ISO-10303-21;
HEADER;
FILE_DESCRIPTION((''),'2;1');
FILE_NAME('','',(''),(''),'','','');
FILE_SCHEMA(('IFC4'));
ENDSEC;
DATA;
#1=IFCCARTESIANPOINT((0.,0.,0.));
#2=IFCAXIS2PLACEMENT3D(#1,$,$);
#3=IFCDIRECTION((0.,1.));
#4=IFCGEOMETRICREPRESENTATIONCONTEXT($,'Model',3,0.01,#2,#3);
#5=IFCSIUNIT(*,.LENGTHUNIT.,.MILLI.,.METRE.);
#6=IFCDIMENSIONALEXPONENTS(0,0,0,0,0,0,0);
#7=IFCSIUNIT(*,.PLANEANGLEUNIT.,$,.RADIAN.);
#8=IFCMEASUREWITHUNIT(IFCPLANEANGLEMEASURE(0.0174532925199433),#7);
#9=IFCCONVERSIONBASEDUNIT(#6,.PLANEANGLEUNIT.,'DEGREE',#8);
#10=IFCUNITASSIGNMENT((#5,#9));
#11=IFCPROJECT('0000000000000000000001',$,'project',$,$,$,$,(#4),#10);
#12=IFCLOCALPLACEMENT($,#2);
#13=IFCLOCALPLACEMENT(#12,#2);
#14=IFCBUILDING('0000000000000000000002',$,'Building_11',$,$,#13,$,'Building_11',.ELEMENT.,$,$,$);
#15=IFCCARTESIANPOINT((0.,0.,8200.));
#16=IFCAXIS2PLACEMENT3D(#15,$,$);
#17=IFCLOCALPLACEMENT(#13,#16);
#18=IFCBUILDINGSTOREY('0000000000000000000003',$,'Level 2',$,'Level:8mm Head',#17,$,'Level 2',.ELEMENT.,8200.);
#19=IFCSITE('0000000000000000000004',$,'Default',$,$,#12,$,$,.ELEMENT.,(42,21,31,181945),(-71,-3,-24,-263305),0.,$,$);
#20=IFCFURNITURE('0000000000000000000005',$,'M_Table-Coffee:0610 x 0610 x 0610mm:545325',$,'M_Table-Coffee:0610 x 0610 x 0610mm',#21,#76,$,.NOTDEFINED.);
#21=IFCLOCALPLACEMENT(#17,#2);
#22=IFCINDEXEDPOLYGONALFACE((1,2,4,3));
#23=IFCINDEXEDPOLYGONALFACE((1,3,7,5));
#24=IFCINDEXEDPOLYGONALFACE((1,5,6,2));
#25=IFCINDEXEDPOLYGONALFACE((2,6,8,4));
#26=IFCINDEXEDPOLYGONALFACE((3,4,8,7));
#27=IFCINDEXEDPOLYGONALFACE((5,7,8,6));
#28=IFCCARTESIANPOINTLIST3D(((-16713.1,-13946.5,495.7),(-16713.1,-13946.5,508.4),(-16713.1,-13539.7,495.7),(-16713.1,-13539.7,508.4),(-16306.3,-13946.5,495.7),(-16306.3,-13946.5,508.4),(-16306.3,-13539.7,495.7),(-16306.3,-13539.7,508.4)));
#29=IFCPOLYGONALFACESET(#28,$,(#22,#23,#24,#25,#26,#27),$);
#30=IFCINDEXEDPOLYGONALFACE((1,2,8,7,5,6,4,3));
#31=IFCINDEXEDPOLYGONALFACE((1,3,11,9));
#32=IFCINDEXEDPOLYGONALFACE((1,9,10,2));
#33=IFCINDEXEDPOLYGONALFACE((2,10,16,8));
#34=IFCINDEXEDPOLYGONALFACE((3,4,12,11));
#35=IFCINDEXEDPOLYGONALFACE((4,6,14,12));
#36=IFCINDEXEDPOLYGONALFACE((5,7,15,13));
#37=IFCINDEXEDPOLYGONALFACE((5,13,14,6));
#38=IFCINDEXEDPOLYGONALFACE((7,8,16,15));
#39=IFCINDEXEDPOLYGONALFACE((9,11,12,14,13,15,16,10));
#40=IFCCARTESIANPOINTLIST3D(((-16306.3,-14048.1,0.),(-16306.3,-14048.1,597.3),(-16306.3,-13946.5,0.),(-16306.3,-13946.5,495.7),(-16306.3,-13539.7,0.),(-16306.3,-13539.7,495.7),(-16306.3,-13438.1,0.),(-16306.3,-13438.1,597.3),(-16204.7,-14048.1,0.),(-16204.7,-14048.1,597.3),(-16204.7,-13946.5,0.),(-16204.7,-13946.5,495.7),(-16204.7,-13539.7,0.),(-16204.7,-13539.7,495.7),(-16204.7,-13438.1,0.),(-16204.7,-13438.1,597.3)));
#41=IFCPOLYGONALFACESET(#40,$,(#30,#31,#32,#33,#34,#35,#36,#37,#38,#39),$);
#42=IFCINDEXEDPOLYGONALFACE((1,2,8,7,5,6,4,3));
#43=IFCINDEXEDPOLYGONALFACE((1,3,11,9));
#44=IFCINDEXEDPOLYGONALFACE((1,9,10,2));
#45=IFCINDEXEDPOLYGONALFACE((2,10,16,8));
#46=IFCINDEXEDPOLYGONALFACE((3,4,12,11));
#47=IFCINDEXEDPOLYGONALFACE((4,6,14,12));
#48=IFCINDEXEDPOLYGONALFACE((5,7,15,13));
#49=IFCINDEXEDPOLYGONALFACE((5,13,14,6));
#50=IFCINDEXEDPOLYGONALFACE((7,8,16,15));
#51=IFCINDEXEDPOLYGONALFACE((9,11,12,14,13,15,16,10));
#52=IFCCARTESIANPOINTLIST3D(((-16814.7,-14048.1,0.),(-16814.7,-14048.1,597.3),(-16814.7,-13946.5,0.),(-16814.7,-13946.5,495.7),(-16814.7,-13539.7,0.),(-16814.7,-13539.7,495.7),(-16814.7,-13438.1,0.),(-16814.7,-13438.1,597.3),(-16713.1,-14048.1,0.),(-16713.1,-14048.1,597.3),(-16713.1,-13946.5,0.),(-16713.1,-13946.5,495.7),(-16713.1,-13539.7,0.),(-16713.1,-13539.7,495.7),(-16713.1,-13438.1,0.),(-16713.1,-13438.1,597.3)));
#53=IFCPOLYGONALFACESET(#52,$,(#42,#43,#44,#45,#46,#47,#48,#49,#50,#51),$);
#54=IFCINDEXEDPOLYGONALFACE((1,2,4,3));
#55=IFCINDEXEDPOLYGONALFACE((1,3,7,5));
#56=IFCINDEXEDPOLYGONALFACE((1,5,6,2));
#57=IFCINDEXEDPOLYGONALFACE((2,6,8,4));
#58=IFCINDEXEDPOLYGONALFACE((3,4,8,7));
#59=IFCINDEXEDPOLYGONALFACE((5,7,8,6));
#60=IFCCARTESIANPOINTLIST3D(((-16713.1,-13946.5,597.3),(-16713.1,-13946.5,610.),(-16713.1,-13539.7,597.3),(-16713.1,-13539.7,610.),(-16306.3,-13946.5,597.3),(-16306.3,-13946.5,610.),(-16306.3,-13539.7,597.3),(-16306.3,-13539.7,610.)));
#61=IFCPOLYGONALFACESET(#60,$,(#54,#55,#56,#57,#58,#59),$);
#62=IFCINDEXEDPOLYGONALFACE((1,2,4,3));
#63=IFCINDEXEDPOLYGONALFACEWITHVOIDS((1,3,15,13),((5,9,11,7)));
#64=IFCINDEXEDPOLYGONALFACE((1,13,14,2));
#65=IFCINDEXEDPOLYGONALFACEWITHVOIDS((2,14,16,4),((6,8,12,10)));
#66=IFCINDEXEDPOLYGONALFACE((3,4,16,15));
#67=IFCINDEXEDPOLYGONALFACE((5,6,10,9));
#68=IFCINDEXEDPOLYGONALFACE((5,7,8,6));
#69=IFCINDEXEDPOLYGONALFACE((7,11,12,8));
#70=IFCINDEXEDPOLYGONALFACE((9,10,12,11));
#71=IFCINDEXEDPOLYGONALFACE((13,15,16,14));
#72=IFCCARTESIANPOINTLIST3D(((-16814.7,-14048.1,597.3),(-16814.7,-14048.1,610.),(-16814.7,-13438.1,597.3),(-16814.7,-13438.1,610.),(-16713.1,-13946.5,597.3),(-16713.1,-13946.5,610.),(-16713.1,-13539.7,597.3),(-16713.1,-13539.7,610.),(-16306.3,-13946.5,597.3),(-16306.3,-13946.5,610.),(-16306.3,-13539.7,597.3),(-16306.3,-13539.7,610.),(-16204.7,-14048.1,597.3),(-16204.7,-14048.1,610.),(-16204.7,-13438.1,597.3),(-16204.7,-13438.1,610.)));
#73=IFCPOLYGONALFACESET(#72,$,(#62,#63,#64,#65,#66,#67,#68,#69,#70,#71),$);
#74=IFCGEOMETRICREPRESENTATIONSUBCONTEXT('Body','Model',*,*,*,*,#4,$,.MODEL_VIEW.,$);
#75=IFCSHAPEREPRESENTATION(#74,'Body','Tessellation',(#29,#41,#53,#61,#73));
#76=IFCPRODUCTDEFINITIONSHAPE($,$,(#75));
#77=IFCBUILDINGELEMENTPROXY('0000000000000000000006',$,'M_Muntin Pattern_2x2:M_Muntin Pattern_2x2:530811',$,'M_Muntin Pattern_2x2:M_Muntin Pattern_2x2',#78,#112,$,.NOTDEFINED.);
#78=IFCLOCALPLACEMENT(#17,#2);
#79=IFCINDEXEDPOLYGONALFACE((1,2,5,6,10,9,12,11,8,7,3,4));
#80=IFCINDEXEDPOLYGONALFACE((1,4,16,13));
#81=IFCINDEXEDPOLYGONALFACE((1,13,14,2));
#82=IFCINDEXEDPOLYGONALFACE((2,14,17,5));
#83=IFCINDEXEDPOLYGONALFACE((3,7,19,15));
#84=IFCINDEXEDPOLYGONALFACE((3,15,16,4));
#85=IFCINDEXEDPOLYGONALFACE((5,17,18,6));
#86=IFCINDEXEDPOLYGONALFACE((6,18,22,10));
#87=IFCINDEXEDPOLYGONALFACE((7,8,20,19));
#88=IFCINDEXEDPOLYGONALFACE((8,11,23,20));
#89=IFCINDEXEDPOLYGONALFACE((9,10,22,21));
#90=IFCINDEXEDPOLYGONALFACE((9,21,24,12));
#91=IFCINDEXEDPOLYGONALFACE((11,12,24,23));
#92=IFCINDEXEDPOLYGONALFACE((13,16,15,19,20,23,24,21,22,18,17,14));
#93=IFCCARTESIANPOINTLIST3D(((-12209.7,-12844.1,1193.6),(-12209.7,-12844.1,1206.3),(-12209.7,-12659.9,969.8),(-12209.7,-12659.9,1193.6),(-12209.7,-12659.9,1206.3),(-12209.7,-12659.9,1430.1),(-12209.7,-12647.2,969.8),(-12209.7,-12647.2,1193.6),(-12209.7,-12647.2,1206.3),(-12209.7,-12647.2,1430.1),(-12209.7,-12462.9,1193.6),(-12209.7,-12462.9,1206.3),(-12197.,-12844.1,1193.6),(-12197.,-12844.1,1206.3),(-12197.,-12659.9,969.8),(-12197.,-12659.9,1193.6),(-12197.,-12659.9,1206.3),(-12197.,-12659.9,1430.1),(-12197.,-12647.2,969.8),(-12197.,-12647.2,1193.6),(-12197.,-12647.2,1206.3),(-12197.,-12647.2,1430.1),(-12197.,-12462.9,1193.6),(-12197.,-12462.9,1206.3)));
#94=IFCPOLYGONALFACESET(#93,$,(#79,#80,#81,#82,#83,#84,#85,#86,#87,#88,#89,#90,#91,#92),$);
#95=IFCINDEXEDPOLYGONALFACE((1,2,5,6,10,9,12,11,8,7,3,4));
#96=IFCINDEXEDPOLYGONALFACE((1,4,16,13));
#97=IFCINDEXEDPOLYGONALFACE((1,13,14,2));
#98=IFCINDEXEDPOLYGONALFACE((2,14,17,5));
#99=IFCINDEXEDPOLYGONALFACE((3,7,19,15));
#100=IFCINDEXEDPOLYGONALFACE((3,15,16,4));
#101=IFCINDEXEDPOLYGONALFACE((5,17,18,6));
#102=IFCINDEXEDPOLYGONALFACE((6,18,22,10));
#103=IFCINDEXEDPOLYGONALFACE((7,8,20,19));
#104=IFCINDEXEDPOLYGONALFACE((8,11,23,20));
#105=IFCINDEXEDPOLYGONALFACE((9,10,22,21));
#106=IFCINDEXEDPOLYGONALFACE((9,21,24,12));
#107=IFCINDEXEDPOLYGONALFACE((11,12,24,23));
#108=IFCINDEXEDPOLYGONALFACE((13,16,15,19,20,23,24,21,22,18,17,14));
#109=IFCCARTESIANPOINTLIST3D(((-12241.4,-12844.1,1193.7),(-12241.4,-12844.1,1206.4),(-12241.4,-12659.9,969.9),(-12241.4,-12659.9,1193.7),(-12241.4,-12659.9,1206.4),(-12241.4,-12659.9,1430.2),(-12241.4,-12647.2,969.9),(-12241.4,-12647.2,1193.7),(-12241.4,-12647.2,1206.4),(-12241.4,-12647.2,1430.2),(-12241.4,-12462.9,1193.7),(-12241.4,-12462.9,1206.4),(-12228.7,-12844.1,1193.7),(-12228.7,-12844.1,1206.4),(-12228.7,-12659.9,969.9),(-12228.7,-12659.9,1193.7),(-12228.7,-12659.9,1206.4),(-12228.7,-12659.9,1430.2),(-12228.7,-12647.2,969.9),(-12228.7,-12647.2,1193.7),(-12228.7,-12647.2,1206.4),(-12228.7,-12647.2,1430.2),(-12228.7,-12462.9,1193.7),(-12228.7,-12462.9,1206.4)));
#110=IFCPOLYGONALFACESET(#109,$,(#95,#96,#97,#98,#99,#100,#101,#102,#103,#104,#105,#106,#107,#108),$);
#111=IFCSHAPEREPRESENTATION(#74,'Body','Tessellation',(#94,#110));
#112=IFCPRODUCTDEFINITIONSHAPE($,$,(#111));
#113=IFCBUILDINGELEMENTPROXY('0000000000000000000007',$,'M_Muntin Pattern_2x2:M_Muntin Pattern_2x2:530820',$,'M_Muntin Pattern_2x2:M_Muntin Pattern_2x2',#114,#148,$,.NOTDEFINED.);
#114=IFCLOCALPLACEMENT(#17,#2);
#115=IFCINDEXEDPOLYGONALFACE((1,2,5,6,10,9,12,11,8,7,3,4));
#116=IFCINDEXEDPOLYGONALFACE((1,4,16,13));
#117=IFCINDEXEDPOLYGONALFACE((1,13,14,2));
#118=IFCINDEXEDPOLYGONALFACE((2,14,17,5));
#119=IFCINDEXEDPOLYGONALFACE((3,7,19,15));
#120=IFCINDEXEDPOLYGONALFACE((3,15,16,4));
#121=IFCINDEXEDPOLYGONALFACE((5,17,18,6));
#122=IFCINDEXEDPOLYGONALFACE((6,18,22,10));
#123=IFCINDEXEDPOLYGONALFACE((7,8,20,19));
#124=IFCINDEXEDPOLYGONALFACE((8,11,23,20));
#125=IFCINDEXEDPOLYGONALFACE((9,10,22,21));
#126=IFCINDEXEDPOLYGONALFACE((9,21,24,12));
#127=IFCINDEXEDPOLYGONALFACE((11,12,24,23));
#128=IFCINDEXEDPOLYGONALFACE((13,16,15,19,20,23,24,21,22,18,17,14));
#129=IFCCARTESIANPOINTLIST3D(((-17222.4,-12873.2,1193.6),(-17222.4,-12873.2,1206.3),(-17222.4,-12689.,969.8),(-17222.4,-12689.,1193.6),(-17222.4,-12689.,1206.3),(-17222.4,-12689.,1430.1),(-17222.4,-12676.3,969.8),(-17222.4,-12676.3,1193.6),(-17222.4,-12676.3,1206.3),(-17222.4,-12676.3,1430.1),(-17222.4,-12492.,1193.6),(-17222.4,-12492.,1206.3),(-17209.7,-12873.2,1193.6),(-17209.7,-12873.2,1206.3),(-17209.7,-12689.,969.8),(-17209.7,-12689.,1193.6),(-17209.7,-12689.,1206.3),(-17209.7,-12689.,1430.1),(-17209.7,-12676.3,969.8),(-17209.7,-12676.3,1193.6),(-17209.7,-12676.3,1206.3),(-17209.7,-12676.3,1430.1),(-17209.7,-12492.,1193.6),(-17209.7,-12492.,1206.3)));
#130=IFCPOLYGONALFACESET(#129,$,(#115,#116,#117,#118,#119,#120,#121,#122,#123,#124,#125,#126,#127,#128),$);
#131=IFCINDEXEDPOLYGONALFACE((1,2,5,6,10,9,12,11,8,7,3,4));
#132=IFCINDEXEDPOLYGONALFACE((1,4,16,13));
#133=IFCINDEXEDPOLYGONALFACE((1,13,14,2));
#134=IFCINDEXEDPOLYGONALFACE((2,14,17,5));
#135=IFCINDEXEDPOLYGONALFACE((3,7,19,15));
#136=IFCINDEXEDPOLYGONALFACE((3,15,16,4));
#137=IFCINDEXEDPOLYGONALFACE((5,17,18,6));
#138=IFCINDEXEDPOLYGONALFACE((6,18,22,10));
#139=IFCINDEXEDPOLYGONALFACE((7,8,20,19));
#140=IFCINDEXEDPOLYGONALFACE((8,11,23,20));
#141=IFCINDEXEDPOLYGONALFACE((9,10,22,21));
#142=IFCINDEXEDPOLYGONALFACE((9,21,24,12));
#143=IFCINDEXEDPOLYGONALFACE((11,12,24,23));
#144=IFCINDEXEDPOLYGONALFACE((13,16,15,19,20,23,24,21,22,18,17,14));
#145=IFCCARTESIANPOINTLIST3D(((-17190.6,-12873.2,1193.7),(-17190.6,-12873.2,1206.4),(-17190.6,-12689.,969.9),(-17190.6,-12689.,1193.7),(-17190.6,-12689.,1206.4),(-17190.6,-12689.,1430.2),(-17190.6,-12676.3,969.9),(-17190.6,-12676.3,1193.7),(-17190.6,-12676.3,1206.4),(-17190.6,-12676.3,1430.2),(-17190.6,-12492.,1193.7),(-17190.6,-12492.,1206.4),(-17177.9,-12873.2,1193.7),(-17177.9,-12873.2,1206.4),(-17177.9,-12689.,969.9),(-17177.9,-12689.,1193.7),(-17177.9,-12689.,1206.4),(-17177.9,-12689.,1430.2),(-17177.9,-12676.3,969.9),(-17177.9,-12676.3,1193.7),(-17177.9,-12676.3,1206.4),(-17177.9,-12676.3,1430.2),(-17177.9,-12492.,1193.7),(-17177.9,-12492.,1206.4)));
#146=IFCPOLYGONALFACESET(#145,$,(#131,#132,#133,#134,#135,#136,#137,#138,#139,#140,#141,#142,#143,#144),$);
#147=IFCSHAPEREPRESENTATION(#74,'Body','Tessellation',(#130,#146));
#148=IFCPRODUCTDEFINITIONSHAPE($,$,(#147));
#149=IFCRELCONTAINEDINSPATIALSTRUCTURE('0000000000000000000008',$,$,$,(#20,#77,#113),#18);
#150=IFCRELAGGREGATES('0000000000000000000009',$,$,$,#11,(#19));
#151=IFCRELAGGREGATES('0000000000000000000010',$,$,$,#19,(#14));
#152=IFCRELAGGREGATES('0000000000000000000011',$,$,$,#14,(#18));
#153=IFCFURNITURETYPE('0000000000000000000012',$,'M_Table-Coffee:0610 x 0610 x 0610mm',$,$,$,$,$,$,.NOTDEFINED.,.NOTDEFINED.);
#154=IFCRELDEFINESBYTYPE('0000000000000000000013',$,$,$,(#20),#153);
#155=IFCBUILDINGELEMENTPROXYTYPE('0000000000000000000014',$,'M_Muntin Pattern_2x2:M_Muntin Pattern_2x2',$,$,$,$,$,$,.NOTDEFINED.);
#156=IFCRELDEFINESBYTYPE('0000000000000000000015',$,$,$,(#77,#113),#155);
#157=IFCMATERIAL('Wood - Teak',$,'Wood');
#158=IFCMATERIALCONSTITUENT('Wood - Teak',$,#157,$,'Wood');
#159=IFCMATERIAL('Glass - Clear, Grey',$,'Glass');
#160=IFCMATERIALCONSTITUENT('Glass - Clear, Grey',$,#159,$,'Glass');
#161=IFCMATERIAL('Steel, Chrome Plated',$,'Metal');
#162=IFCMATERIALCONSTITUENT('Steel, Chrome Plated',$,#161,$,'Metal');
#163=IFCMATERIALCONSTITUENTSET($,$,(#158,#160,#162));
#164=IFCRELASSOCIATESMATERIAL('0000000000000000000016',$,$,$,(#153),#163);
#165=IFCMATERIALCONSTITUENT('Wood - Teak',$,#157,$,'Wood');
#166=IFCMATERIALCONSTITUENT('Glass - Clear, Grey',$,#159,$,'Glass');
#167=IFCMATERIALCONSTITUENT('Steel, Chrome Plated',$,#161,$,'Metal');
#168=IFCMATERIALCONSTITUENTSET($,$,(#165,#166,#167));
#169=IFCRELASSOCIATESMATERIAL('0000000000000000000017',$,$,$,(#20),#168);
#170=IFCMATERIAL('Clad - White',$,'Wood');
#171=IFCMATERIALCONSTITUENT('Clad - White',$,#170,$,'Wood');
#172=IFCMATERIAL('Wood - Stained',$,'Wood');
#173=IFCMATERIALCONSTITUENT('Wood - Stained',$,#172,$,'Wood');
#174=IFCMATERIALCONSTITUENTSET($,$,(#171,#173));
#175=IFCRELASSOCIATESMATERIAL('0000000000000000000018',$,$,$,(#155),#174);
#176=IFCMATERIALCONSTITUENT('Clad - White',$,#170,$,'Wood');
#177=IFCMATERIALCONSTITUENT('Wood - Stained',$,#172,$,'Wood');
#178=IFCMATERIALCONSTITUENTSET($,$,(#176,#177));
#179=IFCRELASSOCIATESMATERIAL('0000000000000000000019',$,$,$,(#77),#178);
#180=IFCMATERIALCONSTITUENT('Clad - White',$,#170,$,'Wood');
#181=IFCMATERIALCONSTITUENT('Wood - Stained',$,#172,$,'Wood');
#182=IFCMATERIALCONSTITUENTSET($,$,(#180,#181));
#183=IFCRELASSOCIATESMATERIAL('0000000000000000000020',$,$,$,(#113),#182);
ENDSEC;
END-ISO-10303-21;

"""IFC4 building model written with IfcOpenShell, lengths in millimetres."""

from ifc_helpers import new_model, entity, si_unit, converted_unit, direction, frame, origin, place, context, subcontext, project, spatial, indexed_curve, outline, extrude, source, transform, mapped, material, constituent, constituent_set, type_object, type_shapes, element, save


model = new_model("IFC4")

# Units and contexts
model_context = context("Model", 3, precision=0.01, world=origin(), true_north=direction((0.0, 1.0)))
body_context = subcontext(model_context, "Body", "Model", "MODEL_VIEW")
ifc_project = project(units=[si_unit("LENGTHUNIT", "METRE", prefix="MILLI"), converted_unit("PLANEANGLEUNIT", "DEGREE", entity("IfcPlaneAngleMeasure", 0.0174532925199433), si_unit("PLANEANGLEUNIT", "RADIAN"), dimensions=[0, 0, 0, 0, 0, 0, 0])], contexts=[model_context])

# Site, building, storey
site_placement = place(None, origin())
site = spatial("IfcSite", under=ifc_project, at=site_placement, Name="Default", CompositionType="ELEMENT", RefLatitude=(42, 21, 31, 181945), RefLongitude=(-71, -3, -24, -263305), RefElevation=0.0)
building_placement = place(site_placement, origin())
building = spatial("IfcBuilding", under=site, at=building_placement, Name="Building_11", LongName="Building_11", CompositionType="ELEMENT")
storey_placement = place(building_placement, frame((0.0, 0.0, 8200.0)))
storey = spatial("IfcBuildingStorey", under=building, at=storey_placement, Name="Level 2", ObjectType="Level:8mm Head", LongName="Level 2", CompositionType="ELEMENT", Elevation=8200.0)

# Furniture
ifc_material_1 = material(Name="Wood - Teak", Category="Wood")
ifc_constituent_1 = constituent(ifc_material_1, Name="Wood - Teak", Category="Wood")
ifc_material_2 = material(Name="Glass - Clear, Grey", Category="Glass")
ifc_constituent_2 = constituent(ifc_material_2, Name="Glass - Clear, Grey", Category="Glass")
ifc_material_3 = material(Name="Steel, Chrome Plated", Category="Metal")
ifc_constituent_3 = constituent(ifc_material_3, Name="Steel, Chrome Plated", Category="Metal")
ifc_constituent_set_1 = constituent_set(constituents=[ifc_constituent_1, ifc_constituent_2, ifc_constituent_3])
ifc_constituent_4 = constituent(ifc_material_1, Name="Wood - Teak", Category="Wood")
ifc_constituent_5 = constituent(ifc_material_2, Name="Glass - Clear, Grey", Category="Glass")
ifc_constituent_6 = constituent(ifc_material_3, Name="Steel, Chrome Plated", Category="Metal")
ifc_constituent_set_2 = constituent_set(constituents=[ifc_constituent_4, ifc_constituent_5, ifc_constituent_6])
furniture_type = type_object("IfcFurnitureType", Name="M_Table-Coffee:0610 x 0610 x 0610mm", AssemblyPlace="NOTDEFINED", PredefinedType="NOTDEFINED", material=ifc_constituent_set_2)
shared_shape_1 = source(origin(), body_context, "Body", "SweptSolid", [
    extrude(outline(indexed_curve([(-203.4, -203.4), (203.4, -203.4), (203.4, 203.4), (-203.4, 203.4), (-203.4, -203.4)], self_intersect=False)), frame((18.3, 95.2, 495.7), z_axis=(0.0, 0.0, 1.0), x_axis=(-1.0, 0.0, 0.0)), (0.0, 0.0, 1.0), 12.7),
    extrude(outline(indexed_curve([(-273.2, -305.0), (324.0, -305.0), (324.0, 305.0), (-273.2, 305.0), (-273.2, 203.4), (222.5, 203.4), (222.5, -203.4), (-273.2, -203.4), (-273.2, -305.0)], self_intersect=False)), frame((221.7, 95.2, 273.2), z_axis=(1.0, 0.0, 0.0), x_axis=(0.0, 0.0, 1.0)), (0.0, 0.0, 1.0), 101.6),
    extrude(outline(indexed_curve([(-305.0, -324.1), (305.0, -324.1), (305.0, 273.3), (203.4, 273.3), (203.4, -222.4), (-203.4, -222.4), (-203.4, 273.3), (-305.0, 273.3), (-305.0, -324.1)], self_intersect=False)), frame((-286.7, 95.2, 273.3), z_axis=(1.0, 0.0, 0.0), x_axis=(0.0, -1.0, 0.0)), (0.0, 0.0, 1.0), 101.6),
    extrude(outline(indexed_curve([(-203.4, -203.4), (203.4, -203.4), (203.4, 203.4), (-203.4, 203.4), (-203.4, -203.4)], self_intersect=False)), frame((18.3, 95.2, 597.3), z_axis=(0.0, 0.0, 1.0), x_axis=(-1.0, 0.0, 0.0)), (0.0, 0.0, 1.0), 12.7),
    extrude(outline(indexed_curve([(-305.0, -305.0), (305.0, -305.0), (305.0, 305.0), (-305.0, 305.0), (-305.0, -305.0)], self_intersect=False), holes=[indexed_curve([(-203.4, -203.4), (-203.4, 203.4), (203.4, 203.4), (203.4, -203.4), (-203.4, -203.4)], self_intersect=False)]), frame((18.3, 95.2, 597.3), z_axis=(0.0, 0.0, 1.0), x_axis=(-1.0, 0.0, 0.0)), (0.0, 0.0, 1.0), 12.7),
])
type_shapes(furniture_type, [shared_shape_1])
furniture_placement = place(storey_placement, frame((-16528.0, -13838.3, 0.0)))
element("IfcFurniture", 1, at=furniture_placement, inside=storey, type_object=furniture_type, material=ifc_constituent_set_1, Name="M_Table-Coffee:0610 x 0610 x 0610mm:545325", ObjectType="M_Table-Coffee:0610 x 0610 x 0610mm", PredefinedType="NOTDEFINED", context=body_context, shape_type="MappedRepresentation", body=[
    mapped(shared_shape_1, transform((0.0, 0.0, 0.0), scale=1.0)),
])

# Building element proxies
ifc_material_4 = material(Name="Clad - White", Category="Wood")
ifc_constituent_7 = constituent(ifc_material_4, Name="Clad - White", Category="Wood")
ifc_material_5 = material(Name="Wood - Stained", Category="Wood")
ifc_constituent_8 = constituent(ifc_material_5, Name="Wood - Stained", Category="Wood")
ifc_constituent_set_3 = constituent_set(constituents=[ifc_constituent_7, ifc_constituent_8])
ifc_constituent_9 = constituent(ifc_material_4, Name="Clad - White", Category="Wood")
ifc_constituent_10 = constituent(ifc_material_5, Name="Wood - Stained", Category="Wood")
ifc_constituent_set_4 = constituent_set(constituents=[ifc_constituent_9, ifc_constituent_10])
building_element_proxy_type_1 = type_object("IfcBuildingElementProxyType", Name="M_Muntin Pattern_2x2:M_Muntin Pattern_2x2", PredefinedType="NOTDEFINED", material=ifc_constituent_set_4)
shared_shape_2 = source(origin(), body_context, "Body", "SweptSolid", [
    extrude(outline(indexed_curve([(6.4, -6.4), (230.1, -6.4), (230.1, 6.3), (6.4, 6.3), (6.4, 190.6), (-6.3, 190.6), (-6.3, 6.3), (-230.2, 6.3), (-230.2, -6.4), (-6.3, -6.4), (-6.3, -190.6), (6.4, -190.6), (6.4, -6.4)], self_intersect=False)), frame((0.0, 9.5, 230.1), z_axis=(0.0, 1.0, 0.0), x_axis=(0.0, 0.0, 1.0)), (0.0, 0.0, 1.0), 12.7),
    extrude(outline(indexed_curve([(6.4, -6.4), (230.2, -6.4), (230.2, 6.3), (6.4, 6.3), (6.4, 190.6), (-6.3, 190.6), (-6.3, 6.3), (-230.2, 6.3), (-230.2, -6.4), (-6.3, -6.4), (-6.3, -190.6), (6.4, -190.6), (6.4, -6.4)], self_intersect=False)), frame((0.0, -22.2, 230.2), z_axis=(0.0, 1.0, 0.0), x_axis=(0.0, 0.0, 1.0)), (0.0, 0.0, 1.0), 12.7),
])
type_shapes(building_element_proxy_type_1, [shared_shape_2])
proxy_1_placement = place(storey_placement, frame((-12219.2, -12653.5, 969.9), z_axis=(0.0, 0.0, 1.0), x_axis=(0.0, -1.0, 0.0)))
element("IfcBuildingElementProxy", 2, at=proxy_1_placement, inside=storey, type_object=building_element_proxy_type_1, material=ifc_constituent_set_3, Name="M_Muntin Pattern_2x2:M_Muntin Pattern_2x2:530811", ObjectType="M_Muntin Pattern_2x2:M_Muntin Pattern_2x2", PredefinedType="NOTDEFINED", context=body_context, shape_type="MappedRepresentation", body=[
    mapped(shared_shape_2, transform((0.0, 0.0, 0.0), scale=1.0)),
])
ifc_constituent_11 = constituent(ifc_material_4, Name="Clad - White", Category="Wood")
ifc_constituent_12 = constituent(ifc_material_5, Name="Wood - Stained", Category="Wood")
ifc_constituent_set_5 = constituent_set(constituents=[ifc_constituent_11, ifc_constituent_12])
proxy_2_placement = place(storey_placement, frame((-17200.2, -12682.6, 969.9), z_axis=(0.0, 0.0, 1.0), x_axis=(0.0, 1.0, 0.0)))
element("IfcBuildingElementProxy", 3, at=proxy_2_placement, inside=storey, type_object=building_element_proxy_type_1, material=ifc_constituent_set_5, Name="M_Muntin Pattern_2x2:M_Muntin Pattern_2x2:530820", ObjectType="M_Muntin Pattern_2x2:M_Muntin Pattern_2x2", PredefinedType="NOTDEFINED", context=body_context, shape_type="MappedRepresentation", body=[
    mapped(shared_shape_2, transform((0.0, 0.0, 0.0), scale=1.0)),
])

save(model, "model.ifc")
